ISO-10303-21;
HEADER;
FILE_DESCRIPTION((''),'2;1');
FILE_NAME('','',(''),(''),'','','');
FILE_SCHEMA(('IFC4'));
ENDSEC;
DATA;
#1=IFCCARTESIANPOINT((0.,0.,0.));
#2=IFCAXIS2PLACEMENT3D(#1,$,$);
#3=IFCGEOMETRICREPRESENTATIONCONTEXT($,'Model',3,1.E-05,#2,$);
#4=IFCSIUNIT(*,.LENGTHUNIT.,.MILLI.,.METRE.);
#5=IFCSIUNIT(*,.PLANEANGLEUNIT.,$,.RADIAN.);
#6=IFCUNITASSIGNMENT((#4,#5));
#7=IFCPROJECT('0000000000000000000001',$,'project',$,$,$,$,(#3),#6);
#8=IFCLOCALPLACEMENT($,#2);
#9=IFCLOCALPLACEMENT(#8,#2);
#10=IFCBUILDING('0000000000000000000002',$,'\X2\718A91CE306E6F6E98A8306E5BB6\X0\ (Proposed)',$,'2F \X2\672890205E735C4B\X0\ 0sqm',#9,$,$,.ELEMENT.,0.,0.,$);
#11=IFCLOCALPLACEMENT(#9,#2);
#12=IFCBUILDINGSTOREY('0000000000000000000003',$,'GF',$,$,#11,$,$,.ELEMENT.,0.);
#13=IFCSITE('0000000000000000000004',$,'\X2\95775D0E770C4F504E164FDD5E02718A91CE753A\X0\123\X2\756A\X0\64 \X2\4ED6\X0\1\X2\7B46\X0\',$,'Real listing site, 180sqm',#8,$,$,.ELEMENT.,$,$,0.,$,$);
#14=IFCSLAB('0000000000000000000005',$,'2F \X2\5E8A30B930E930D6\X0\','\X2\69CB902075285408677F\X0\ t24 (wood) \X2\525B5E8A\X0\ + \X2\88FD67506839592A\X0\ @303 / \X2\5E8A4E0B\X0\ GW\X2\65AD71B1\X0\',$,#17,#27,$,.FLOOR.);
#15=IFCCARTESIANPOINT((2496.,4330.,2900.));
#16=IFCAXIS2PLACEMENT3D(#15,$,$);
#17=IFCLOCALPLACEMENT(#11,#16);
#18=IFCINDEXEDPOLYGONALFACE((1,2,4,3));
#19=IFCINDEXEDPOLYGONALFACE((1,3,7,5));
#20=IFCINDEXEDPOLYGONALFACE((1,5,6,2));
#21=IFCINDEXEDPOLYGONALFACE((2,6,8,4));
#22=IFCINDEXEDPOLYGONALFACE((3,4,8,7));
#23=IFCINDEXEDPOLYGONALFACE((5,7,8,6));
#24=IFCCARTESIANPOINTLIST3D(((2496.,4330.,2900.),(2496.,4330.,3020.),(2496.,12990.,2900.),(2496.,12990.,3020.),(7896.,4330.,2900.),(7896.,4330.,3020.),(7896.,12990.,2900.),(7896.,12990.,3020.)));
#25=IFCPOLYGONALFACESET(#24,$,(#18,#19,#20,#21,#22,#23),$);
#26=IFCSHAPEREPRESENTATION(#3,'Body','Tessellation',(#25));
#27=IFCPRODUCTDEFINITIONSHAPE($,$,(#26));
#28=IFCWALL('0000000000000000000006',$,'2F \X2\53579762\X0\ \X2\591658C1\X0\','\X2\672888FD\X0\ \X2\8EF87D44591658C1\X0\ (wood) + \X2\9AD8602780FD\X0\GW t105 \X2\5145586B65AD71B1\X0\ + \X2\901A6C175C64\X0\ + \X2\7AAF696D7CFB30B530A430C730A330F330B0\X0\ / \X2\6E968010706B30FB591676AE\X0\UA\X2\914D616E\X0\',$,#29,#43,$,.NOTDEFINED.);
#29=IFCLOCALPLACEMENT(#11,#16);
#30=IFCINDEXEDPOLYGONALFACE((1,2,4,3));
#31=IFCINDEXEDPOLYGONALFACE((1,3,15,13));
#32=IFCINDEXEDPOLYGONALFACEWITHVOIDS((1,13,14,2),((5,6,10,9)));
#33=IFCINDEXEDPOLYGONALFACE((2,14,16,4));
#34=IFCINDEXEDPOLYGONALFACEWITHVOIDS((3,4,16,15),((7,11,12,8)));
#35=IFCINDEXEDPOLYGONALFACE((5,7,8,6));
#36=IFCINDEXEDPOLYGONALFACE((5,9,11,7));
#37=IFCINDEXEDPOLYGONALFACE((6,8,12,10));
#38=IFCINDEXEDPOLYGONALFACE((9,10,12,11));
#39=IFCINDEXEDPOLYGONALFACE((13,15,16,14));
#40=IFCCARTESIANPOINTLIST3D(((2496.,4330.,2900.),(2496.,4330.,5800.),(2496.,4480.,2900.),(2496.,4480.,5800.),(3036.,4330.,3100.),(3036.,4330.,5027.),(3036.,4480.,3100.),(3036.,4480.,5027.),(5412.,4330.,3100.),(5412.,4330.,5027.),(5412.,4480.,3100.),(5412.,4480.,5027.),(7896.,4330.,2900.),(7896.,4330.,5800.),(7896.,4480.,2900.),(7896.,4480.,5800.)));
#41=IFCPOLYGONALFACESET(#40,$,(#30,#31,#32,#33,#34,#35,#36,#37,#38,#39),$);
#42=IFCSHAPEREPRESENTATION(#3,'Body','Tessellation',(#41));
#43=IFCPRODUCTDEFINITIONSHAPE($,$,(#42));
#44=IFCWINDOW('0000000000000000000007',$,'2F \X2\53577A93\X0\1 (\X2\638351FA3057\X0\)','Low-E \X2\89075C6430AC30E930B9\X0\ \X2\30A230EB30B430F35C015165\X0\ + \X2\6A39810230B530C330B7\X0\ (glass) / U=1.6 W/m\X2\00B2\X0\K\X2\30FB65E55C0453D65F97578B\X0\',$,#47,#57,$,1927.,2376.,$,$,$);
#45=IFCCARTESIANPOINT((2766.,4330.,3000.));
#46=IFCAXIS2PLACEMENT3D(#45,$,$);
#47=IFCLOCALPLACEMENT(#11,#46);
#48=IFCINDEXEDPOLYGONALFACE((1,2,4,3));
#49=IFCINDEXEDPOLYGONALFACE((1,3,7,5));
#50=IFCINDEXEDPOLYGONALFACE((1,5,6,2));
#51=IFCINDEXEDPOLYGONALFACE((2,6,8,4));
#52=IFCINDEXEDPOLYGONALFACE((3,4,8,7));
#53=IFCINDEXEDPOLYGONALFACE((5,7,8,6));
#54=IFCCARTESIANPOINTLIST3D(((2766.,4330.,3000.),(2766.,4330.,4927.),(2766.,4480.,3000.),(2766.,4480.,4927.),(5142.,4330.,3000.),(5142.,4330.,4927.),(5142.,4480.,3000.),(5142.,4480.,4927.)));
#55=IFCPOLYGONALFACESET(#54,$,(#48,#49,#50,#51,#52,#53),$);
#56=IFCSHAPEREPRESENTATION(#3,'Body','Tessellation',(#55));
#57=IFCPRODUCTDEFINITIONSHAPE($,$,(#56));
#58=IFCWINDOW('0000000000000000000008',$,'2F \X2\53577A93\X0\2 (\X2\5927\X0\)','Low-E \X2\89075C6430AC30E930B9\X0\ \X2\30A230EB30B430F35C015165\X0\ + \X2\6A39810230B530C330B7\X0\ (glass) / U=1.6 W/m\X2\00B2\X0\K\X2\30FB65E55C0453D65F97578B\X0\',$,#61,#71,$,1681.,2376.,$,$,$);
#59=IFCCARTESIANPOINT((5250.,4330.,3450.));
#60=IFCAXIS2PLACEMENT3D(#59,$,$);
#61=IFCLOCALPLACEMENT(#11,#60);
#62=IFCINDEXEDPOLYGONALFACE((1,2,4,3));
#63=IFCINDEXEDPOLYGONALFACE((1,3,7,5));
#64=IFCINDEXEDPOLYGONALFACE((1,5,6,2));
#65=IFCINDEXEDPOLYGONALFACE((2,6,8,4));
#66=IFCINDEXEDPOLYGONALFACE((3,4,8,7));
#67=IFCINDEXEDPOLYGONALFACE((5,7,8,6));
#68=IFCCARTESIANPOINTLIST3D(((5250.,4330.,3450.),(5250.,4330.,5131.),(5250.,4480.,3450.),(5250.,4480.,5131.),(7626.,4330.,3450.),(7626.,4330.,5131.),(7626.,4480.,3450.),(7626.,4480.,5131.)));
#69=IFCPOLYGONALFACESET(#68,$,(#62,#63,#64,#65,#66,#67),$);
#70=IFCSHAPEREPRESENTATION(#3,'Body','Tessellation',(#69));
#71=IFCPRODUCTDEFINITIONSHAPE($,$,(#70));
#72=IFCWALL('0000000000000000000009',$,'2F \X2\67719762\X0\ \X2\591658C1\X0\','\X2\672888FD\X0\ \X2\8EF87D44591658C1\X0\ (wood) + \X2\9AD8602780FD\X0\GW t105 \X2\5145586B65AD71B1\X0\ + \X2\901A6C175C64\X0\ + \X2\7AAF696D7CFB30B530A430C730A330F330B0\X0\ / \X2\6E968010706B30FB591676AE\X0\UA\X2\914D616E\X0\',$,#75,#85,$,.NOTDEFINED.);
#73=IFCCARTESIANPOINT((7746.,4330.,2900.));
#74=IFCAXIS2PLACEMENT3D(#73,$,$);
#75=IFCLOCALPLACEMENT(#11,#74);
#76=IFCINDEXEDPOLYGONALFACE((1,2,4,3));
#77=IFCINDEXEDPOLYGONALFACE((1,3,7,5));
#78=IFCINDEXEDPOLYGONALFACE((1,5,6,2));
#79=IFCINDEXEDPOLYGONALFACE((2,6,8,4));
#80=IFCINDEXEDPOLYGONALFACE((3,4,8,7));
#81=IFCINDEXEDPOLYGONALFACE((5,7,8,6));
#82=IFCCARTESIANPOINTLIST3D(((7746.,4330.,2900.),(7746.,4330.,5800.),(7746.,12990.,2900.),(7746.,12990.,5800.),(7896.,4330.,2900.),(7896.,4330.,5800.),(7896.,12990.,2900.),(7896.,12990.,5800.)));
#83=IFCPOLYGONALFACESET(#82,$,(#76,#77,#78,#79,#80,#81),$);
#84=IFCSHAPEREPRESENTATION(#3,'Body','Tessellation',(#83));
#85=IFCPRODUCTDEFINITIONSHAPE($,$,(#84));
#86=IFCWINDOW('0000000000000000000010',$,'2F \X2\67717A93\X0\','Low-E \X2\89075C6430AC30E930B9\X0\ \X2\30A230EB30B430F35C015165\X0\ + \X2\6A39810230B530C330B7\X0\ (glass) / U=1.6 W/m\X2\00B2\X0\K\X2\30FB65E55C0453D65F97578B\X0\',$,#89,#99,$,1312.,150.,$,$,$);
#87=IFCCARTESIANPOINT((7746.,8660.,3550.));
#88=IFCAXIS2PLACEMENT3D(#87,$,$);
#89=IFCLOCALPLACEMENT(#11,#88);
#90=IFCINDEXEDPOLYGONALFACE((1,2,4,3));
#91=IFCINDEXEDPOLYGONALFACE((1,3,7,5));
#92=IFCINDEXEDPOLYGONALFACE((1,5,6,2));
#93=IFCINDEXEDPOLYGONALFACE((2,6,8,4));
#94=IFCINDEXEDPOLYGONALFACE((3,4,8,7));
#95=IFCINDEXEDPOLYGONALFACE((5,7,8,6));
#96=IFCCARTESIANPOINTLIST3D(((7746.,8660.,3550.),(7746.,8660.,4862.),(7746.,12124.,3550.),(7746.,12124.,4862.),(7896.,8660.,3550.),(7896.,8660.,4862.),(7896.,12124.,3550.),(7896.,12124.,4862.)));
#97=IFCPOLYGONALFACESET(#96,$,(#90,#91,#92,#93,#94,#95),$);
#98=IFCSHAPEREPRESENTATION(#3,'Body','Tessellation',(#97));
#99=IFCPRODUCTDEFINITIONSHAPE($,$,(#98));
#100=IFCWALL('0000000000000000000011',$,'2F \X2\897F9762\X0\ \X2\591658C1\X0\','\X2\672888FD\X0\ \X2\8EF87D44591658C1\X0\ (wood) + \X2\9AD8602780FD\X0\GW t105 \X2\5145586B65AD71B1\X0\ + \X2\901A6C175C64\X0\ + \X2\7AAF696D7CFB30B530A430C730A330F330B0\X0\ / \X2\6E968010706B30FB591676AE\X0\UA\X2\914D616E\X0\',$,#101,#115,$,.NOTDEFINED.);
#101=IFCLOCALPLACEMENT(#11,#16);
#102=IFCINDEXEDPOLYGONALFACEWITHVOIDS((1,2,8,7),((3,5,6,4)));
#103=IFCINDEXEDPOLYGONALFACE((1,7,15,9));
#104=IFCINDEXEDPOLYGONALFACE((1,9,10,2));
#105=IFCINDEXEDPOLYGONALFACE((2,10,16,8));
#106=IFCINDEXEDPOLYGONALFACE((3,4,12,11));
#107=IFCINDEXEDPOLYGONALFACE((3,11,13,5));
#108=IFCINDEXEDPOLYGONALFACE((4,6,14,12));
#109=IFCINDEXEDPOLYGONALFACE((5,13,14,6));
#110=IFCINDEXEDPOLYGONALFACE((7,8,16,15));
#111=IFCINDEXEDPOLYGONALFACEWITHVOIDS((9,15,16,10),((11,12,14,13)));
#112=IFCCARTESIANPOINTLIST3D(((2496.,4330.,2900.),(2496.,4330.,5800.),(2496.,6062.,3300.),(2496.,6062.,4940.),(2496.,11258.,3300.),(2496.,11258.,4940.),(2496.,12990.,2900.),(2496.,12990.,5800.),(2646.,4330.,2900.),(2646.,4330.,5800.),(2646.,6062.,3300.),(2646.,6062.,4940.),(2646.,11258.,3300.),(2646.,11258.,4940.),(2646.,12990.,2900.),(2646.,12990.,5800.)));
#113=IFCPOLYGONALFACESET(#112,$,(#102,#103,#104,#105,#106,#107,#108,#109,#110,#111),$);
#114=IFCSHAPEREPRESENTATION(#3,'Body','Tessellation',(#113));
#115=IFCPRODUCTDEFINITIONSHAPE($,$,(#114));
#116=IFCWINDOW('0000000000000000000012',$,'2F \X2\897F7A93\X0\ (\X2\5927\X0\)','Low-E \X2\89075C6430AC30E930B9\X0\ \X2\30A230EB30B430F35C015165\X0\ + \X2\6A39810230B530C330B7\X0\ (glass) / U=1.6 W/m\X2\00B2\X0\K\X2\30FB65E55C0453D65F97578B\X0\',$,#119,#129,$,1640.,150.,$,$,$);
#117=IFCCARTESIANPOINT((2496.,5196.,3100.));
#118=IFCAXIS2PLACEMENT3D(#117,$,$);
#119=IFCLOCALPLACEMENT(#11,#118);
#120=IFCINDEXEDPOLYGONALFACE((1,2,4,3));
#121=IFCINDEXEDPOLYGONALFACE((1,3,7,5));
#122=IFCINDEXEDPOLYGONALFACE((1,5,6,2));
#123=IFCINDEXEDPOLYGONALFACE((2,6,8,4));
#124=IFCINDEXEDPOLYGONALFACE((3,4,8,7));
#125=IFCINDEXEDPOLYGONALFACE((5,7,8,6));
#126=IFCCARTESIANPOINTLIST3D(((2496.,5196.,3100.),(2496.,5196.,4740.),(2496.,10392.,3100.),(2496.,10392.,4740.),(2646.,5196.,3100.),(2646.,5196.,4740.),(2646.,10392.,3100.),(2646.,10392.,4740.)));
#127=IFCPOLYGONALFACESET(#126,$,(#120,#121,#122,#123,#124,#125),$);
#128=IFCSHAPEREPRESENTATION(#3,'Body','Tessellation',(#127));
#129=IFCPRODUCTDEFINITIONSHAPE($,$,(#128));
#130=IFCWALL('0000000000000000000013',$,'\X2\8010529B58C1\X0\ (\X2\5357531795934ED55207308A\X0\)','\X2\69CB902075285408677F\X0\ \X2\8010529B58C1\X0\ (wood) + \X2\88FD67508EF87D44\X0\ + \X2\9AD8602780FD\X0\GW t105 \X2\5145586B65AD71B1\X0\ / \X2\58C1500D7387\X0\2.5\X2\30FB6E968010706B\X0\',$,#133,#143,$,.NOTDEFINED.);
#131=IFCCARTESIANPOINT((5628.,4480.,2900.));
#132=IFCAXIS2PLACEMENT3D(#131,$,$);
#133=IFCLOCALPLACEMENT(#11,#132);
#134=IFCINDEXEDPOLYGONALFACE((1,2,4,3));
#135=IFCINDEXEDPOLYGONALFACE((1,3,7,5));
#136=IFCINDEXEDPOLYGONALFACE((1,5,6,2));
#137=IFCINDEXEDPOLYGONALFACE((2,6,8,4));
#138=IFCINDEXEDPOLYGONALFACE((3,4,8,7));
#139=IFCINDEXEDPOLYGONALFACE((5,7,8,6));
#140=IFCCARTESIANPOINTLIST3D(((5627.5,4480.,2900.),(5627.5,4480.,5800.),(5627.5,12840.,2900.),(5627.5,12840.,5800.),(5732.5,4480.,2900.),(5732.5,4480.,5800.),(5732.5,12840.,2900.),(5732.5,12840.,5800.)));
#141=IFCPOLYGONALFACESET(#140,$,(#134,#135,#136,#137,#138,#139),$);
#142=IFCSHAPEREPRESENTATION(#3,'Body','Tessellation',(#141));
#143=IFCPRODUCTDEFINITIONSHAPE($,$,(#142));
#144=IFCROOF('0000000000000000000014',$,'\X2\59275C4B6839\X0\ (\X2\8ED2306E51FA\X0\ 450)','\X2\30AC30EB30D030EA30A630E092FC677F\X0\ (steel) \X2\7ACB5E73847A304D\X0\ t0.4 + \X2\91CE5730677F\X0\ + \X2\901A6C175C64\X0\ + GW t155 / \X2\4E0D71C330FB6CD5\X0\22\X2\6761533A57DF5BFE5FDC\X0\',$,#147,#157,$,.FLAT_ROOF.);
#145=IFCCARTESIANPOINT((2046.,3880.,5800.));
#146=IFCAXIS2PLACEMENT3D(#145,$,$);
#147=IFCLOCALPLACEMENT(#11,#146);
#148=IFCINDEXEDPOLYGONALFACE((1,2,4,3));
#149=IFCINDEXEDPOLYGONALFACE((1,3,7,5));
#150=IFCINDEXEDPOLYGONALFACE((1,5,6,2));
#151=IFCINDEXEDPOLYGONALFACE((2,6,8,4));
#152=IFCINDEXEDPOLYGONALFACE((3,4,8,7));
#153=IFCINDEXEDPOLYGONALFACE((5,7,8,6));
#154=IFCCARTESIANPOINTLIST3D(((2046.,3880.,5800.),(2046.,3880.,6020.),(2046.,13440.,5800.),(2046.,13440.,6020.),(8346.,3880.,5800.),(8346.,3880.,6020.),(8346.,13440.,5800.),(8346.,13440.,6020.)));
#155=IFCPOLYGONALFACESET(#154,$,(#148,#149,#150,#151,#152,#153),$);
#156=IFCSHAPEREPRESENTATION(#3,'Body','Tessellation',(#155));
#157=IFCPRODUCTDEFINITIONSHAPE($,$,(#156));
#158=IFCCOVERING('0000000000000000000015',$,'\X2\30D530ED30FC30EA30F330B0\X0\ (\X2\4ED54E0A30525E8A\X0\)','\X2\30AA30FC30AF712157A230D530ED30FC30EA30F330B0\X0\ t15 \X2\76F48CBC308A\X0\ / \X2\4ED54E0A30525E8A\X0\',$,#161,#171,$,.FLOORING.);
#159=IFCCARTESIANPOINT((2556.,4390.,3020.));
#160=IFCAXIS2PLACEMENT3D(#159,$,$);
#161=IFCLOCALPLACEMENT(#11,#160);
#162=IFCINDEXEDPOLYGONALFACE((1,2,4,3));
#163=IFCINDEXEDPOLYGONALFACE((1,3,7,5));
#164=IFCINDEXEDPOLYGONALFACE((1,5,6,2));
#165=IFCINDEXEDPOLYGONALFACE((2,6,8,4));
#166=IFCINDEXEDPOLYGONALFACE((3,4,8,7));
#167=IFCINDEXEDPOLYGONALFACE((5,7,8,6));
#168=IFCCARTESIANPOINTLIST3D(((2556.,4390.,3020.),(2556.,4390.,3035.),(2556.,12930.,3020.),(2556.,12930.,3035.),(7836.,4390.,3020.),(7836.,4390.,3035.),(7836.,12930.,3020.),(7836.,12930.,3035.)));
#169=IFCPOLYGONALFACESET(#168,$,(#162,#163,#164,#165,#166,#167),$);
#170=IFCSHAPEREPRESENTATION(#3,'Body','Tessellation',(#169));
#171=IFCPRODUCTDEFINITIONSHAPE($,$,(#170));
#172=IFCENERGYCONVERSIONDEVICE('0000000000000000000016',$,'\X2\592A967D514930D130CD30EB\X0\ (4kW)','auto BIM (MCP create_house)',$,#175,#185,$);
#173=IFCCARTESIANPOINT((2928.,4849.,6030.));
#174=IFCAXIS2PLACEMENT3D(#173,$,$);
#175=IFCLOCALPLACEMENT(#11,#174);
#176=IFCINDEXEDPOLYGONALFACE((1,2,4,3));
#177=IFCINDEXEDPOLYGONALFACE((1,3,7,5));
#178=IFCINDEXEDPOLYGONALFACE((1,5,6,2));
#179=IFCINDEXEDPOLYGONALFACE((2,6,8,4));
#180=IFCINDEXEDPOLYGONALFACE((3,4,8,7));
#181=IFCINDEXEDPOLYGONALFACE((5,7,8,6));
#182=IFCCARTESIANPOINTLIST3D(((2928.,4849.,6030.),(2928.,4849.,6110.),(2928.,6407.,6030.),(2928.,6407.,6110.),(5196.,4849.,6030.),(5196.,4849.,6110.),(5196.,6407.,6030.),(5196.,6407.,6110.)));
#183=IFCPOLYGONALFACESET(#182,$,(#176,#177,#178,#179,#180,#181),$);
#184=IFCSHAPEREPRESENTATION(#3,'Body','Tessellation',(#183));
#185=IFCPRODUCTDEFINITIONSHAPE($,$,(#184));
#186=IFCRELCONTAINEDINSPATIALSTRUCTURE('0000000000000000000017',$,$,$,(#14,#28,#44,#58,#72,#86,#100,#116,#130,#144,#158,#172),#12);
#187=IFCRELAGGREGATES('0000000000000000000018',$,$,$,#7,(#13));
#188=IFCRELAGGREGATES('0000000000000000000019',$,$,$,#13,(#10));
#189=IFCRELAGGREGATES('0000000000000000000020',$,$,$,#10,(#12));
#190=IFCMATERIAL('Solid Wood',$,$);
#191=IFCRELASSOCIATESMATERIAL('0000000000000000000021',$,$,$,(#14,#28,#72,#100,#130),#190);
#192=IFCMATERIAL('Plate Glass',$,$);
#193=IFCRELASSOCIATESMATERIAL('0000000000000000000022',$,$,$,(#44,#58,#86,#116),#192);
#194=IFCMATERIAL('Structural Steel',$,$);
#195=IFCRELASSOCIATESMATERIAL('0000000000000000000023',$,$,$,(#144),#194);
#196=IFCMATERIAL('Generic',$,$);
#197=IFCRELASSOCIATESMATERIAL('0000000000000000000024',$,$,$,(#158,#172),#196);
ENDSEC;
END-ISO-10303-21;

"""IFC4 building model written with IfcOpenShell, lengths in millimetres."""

from ifc_helpers import new_model, si_unit, frame, frame_2d, origin, place, context, project, spatial, rectangle, extrude, material, element, fill, save


model = new_model("IFC4")

# Units and contexts
model_context = context("Model", 3, precision=1e-05, world=origin())
ifc_project = project(units=[si_unit("LENGTHUNIT", "METRE", prefix="MILLI"), si_unit("PLANEANGLEUNIT", "RADIAN")], contexts=[model_context])

# Site, building, storey
site_placement = place(None, origin())
site = spatial("IfcSite", under=ifc_project, at=site_placement, Name="長崎県佐世保市熊野町123番64 他1筆", ObjectType="Real listing site, 180sqm", CompositionType="ELEMENT", RefElevation=0.0)
building_placement = place(site_placement, origin())
building = spatial("IfcBuilding", under=site, at=building_placement, Name="熊野の潮風の家 (Proposed)", ObjectType="2F 木造平屋 0sqm", CompositionType="ELEMENT", ElevationOfRefHeight=0.0, ElevationOfTerrain=0.0)
storey_placement = place(building_placement, origin())
storey = spatial("IfcBuildingStorey", under=building, at=storey_placement, Name="GF", CompositionType="ELEMENT", Elevation=0.0)

# Slab
ifc_material_1 = material(Name="Solid Wood")
slab_placement = place(storey_placement, frame((2496.0, 4330.0, 2900.0)))
element("IfcSlab", 1, at=slab_placement, inside=storey, material=ifc_material_1, Name="2F 床スラブ", Description="構造用合板 t24 (wood) 剛床 + 製材根太 @303 / 床下 GW断熱", PredefinedType="FLOOR", context=model_context, shape_type="SweptSolid", body=[
    extrude(rectangle(XDim=5400.0, YDim=8660.0, at=frame_2d((2700.0, 4330.0))), frame((2496.0, 4330.0, 2900.0)), (0.0, 0.0, 1.0), 120.0),
])

# Wall, openings, windows
wall_1_placement = place(storey_placement, frame((2496.0, 4330.0, 2900.0)))
wall_1 = element("IfcWall", 2, at=wall_1_placement, inside=storey, material=ifc_material_1, Name="2F 南面 外壁", Description="木製 軸組外壁 (wood) + 高性能GW t105 充填断熱 + 通気層 + 窯業系サイディング / 準耐火・外皮UA配慮", PredefinedType="NOTDEFINED", context=model_context, shape_type="SweptSolid", body=[
    extrude(rectangle(XDim=5400.0, YDim=150.0, at=frame_2d((2700.0, 75.0))), frame((2496.0, 4330.0, 2900.0)), (0.0, 0.0, 1.0), 2900.0),
])
opening_1_placement = place(storey_placement, frame((2766.0, 4330.0, 3000.0)))
opening_1 = element("IfcOpeningElement", 3, at=opening_1_placement, cuts=wall_1, PredefinedType="NOTDEFINED", context=model_context, shape_type="SweptSolid", body=[
    extrude(rectangle(XDim=2376.0, YDim=150.0, at=frame_2d((1188.0, 75.0))), frame((2766.0, 4330.0, 3000.0)), (0.0, 0.0, 1.0), 1927.0),
])
opening_2_placement = place(storey_placement, frame((5250.0, 4330.0, 3450.0)))
opening_2 = element("IfcOpeningElement", 4, at=opening_2_placement, cuts=wall_1, PredefinedType="NOTDEFINED", context=model_context, shape_type="SweptSolid", body=[
    extrude(rectangle(XDim=2376.0, YDim=150.0, at=frame_2d((1188.0, 75.0))), frame((5250.0, 4330.0, 3450.0)), (0.0, 0.0, 1.0), 1681.0),
])
ifc_material_2 = material(Name="Plate Glass")
window_1_placement = place(storey_placement, frame((2766.0, 4330.0, 3000.0)))
window_1 = element("IfcWindow", 5, at=window_1_placement, inside=storey, material=ifc_material_2, Name="2F 南窓1 (掃出し)", Description="Low-E 複層ガラス アルゴン封入 + 樹脂サッシ (glass) / U=1.6 W/m²K・日射取得型", OverallHeight=1927.0, OverallWidth=2376.0, context=model_context, shape_type="SweptSolid", body=[
    extrude(rectangle(XDim=2376.0, YDim=150.0, at=frame_2d((1188.0, 75.0))), frame((2766.0, 4330.0, 3000.0)), (0.0, 0.0, 1.0), 1927.0),
])
fill(opening_1, window_1)
window_2_placement = place(storey_placement, frame((5250.0, 4330.0, 3450.0)))
window_2 = element("IfcWindow", 6, at=window_2_placement, inside=storey, material=ifc_material_2, Name="2F 南窓2 (大)", Description="Low-E 複層ガラス アルゴン封入 + 樹脂サッシ (glass) / U=1.6 W/m²K・日射取得型", OverallHeight=1681.0, OverallWidth=2376.0, context=model_context, shape_type="SweptSolid", body=[
    extrude(rectangle(XDim=2376.0, YDim=150.0, at=frame_2d((1188.0, 75.0))), frame((5250.0, 4330.0, 3450.0)), (0.0, 0.0, 1.0), 1681.0),
])
fill(opening_2, window_2)

# Walls, openings, windows
wall_2_placement = place(storey_placement, frame((7746.0, 4330.0, 2900.0)))
wall_2 = element("IfcWall", 7, at=wall_2_placement, inside=storey, material=ifc_material_1, Name="2F 東面 外壁", Description="木製 軸組外壁 (wood) + 高性能GW t105 充填断熱 + 通気層 + 窯業系サイディング / 準耐火・外皮UA配慮", PredefinedType="NOTDEFINED", context=model_context, shape_type="SweptSolid", body=[
    extrude(rectangle(XDim=150.0, YDim=8660.0, at=frame_2d((75.0, 4330.0))), frame((7746.0, 4330.0, 2900.0)), (0.0, 0.0, 1.0), 2900.0),
])
opening_3_placement = place(storey_placement, frame((7746.0, 8660.0, 3550.0)))
opening_3 = element("IfcOpeningElement", 8, at=opening_3_placement, cuts=wall_2, PredefinedType="NOTDEFINED", context=model_context, shape_type="SweptSolid", body=[
    extrude(rectangle(XDim=150.0, YDim=3464.0, at=frame_2d((75.0, 1732.0))), frame((7746.0, 8660.0, 3550.0)), (0.0, 0.0, 1.0), 1312.0),
])
window_3_placement = place(storey_placement, frame((7746.0, 8660.0, 3550.0)))
window_3 = element("IfcWindow", 9, at=window_3_placement, inside=storey, material=ifc_material_2, Name="2F 東窓", Description="Low-E 複層ガラス アルゴン封入 + 樹脂サッシ (glass) / U=1.6 W/m²K・日射取得型", OverallHeight=1312.0, OverallWidth=150.0, context=model_context, shape_type="SweptSolid", body=[
    extrude(rectangle(XDim=150.0, YDim=3464.0, at=frame_2d((75.0, 1732.0))), frame((7746.0, 8660.0, 3550.0)), (0.0, 0.0, 1.0), 1312.0),
])
fill(opening_3, window_3)
wall_3_placement = place(storey_placement, frame((2496.0, 4330.0, 2900.0)))
wall_3 = element("IfcWall", 10, at=wall_3_placement, inside=storey, material=ifc_material_1, Name="2F 西面 外壁", Description="木製 軸組外壁 (wood) + 高性能GW t105 充填断熱 + 通気層 + 窯業系サイディング / 準耐火・外皮UA配慮", PredefinedType="NOTDEFINED", context=model_context, shape_type="SweptSolid", body=[
    extrude(rectangle(XDim=150.0, YDim=8660.0, at=frame_2d((75.0, 4330.0))), frame((2496.0, 4330.0, 2900.0)), (0.0, 0.0, 1.0), 2900.0),
])
opening_4_placement = place(storey_placement, frame((2496.0, 5196.0, 3100.0)))
opening_4 = element("IfcOpeningElement", 11, at=opening_4_placement, cuts=wall_3, PredefinedType="NOTDEFINED", context=model_context, shape_type="SweptSolid", body=[
    extrude(rectangle(XDim=150.0, YDim=5196.0, at=frame_2d((75.0, 2598.0))), frame((2496.0, 5196.0, 3100.0)), (0.0, 0.0, 1.0), 1640.0),
])
window_4_placement = place(storey_placement, frame((2496.0, 5196.0, 3100.0)))
window_4 = element("IfcWindow", 12, at=window_4_placement, inside=storey, material=ifc_material_2, Name="2F 西窓 (大)", Description="Low-E 複層ガラス アルゴン封入 + 樹脂サッシ (glass) / U=1.6 W/m²K・日射取得型", OverallHeight=1640.0, OverallWidth=150.0, context=model_context, shape_type="SweptSolid", body=[
    extrude(rectangle(XDim=150.0, YDim=5196.0, at=frame_2d((75.0, 2598.0))), frame((2496.0, 5196.0, 3100.0)), (0.0, 0.0, 1.0), 1640.0),
])
fill(opening_4, window_4)

# Wall
wall_4_placement = place(storey_placement, frame((5628.0, 4480.0, 2900.0)))
element("IfcWall", 13, at=wall_4_placement, inside=storey, material=ifc_material_1, Name="耐力壁 (南北間仕切り)", Description="構造用合板 耐力壁 (wood) + 製材軸組 + 高性能GW t105 充填断熱 / 壁倍率2.5・準耐火", PredefinedType="NOTDEFINED", context=model_context, shape_type="SweptSolid", body=[
    extrude(rectangle(XDim=105.0, YDim=8360.0, at=frame_2d((52.0, 4180.0))), frame((5628.0, 4480.0, 2900.0)), (0.0, 0.0, 1.0), 2900.0),
])

# Roof
ifc_material_3 = material(Name="Structural Steel")
roof_placement = place(storey_placement, frame((2046.0, 3880.0, 5800.0)))
element("IfcRoof", 14, at=roof_placement, inside=storey, material=ifc_material_3, Name="大屋根 (軒の出 450)", Description="ガルバリウム鋼板 (steel) 立平葺き t0.4 + 野地板 + 通気層 + GW t155 / 不燃・法22条区域対応", PredefinedType="FLAT_ROOF", context=model_context, shape_type="SweptSolid", body=[
    extrude(rectangle(XDim=6300.0, YDim=9560.0, at=frame_2d((3150.0, 4780.0))), frame((2046.0, 3880.0, 5800.0)), (0.0, 0.0, 1.0), 220.0),
])

# Covering
ifc_material_4 = material(Name="Generic")
covering_placement = place(storey_placement, frame((2556.0, 4390.0, 3020.0)))
element("IfcCovering", 15, at=covering_placement, inside=storey, material=ifc_material_4, Name="フローリング (仕上げ床)", Description="オーク無垢フローリング t15 直貼り / 仕上げ床", PredefinedType="FLOORING", context=model_context, shape_type="SweptSolid", body=[
    extrude(rectangle(XDim=5280.0, YDim=8540.0, at=frame_2d((2640.0, 4270.0))), frame((2556.0, 4390.0, 3020.0)), (0.0, 0.0, 1.0), 15.0),
])

# Energy conversion device
energy_conversion_device_placement = place(storey_placement, frame((2928.0, 4849.0, 6030.0)))
element("IfcEnergyConversionDevice", 16, at=energy_conversion_device_placement, inside=storey, material=ifc_material_4, Name="太陽光パネル (4kW)", Description="auto BIM (MCP create_house)", context=model_context, shape_type="SweptSolid", body=[
    extrude(rectangle(XDim=2268.0, YDim=1558.0, at=frame_2d((1134.0, 779.0))), frame((2928.0, 4849.0, 6030.0)), (0.0, 0.0, 1.0), 80.0),
])

save(model, "model.ifc")
